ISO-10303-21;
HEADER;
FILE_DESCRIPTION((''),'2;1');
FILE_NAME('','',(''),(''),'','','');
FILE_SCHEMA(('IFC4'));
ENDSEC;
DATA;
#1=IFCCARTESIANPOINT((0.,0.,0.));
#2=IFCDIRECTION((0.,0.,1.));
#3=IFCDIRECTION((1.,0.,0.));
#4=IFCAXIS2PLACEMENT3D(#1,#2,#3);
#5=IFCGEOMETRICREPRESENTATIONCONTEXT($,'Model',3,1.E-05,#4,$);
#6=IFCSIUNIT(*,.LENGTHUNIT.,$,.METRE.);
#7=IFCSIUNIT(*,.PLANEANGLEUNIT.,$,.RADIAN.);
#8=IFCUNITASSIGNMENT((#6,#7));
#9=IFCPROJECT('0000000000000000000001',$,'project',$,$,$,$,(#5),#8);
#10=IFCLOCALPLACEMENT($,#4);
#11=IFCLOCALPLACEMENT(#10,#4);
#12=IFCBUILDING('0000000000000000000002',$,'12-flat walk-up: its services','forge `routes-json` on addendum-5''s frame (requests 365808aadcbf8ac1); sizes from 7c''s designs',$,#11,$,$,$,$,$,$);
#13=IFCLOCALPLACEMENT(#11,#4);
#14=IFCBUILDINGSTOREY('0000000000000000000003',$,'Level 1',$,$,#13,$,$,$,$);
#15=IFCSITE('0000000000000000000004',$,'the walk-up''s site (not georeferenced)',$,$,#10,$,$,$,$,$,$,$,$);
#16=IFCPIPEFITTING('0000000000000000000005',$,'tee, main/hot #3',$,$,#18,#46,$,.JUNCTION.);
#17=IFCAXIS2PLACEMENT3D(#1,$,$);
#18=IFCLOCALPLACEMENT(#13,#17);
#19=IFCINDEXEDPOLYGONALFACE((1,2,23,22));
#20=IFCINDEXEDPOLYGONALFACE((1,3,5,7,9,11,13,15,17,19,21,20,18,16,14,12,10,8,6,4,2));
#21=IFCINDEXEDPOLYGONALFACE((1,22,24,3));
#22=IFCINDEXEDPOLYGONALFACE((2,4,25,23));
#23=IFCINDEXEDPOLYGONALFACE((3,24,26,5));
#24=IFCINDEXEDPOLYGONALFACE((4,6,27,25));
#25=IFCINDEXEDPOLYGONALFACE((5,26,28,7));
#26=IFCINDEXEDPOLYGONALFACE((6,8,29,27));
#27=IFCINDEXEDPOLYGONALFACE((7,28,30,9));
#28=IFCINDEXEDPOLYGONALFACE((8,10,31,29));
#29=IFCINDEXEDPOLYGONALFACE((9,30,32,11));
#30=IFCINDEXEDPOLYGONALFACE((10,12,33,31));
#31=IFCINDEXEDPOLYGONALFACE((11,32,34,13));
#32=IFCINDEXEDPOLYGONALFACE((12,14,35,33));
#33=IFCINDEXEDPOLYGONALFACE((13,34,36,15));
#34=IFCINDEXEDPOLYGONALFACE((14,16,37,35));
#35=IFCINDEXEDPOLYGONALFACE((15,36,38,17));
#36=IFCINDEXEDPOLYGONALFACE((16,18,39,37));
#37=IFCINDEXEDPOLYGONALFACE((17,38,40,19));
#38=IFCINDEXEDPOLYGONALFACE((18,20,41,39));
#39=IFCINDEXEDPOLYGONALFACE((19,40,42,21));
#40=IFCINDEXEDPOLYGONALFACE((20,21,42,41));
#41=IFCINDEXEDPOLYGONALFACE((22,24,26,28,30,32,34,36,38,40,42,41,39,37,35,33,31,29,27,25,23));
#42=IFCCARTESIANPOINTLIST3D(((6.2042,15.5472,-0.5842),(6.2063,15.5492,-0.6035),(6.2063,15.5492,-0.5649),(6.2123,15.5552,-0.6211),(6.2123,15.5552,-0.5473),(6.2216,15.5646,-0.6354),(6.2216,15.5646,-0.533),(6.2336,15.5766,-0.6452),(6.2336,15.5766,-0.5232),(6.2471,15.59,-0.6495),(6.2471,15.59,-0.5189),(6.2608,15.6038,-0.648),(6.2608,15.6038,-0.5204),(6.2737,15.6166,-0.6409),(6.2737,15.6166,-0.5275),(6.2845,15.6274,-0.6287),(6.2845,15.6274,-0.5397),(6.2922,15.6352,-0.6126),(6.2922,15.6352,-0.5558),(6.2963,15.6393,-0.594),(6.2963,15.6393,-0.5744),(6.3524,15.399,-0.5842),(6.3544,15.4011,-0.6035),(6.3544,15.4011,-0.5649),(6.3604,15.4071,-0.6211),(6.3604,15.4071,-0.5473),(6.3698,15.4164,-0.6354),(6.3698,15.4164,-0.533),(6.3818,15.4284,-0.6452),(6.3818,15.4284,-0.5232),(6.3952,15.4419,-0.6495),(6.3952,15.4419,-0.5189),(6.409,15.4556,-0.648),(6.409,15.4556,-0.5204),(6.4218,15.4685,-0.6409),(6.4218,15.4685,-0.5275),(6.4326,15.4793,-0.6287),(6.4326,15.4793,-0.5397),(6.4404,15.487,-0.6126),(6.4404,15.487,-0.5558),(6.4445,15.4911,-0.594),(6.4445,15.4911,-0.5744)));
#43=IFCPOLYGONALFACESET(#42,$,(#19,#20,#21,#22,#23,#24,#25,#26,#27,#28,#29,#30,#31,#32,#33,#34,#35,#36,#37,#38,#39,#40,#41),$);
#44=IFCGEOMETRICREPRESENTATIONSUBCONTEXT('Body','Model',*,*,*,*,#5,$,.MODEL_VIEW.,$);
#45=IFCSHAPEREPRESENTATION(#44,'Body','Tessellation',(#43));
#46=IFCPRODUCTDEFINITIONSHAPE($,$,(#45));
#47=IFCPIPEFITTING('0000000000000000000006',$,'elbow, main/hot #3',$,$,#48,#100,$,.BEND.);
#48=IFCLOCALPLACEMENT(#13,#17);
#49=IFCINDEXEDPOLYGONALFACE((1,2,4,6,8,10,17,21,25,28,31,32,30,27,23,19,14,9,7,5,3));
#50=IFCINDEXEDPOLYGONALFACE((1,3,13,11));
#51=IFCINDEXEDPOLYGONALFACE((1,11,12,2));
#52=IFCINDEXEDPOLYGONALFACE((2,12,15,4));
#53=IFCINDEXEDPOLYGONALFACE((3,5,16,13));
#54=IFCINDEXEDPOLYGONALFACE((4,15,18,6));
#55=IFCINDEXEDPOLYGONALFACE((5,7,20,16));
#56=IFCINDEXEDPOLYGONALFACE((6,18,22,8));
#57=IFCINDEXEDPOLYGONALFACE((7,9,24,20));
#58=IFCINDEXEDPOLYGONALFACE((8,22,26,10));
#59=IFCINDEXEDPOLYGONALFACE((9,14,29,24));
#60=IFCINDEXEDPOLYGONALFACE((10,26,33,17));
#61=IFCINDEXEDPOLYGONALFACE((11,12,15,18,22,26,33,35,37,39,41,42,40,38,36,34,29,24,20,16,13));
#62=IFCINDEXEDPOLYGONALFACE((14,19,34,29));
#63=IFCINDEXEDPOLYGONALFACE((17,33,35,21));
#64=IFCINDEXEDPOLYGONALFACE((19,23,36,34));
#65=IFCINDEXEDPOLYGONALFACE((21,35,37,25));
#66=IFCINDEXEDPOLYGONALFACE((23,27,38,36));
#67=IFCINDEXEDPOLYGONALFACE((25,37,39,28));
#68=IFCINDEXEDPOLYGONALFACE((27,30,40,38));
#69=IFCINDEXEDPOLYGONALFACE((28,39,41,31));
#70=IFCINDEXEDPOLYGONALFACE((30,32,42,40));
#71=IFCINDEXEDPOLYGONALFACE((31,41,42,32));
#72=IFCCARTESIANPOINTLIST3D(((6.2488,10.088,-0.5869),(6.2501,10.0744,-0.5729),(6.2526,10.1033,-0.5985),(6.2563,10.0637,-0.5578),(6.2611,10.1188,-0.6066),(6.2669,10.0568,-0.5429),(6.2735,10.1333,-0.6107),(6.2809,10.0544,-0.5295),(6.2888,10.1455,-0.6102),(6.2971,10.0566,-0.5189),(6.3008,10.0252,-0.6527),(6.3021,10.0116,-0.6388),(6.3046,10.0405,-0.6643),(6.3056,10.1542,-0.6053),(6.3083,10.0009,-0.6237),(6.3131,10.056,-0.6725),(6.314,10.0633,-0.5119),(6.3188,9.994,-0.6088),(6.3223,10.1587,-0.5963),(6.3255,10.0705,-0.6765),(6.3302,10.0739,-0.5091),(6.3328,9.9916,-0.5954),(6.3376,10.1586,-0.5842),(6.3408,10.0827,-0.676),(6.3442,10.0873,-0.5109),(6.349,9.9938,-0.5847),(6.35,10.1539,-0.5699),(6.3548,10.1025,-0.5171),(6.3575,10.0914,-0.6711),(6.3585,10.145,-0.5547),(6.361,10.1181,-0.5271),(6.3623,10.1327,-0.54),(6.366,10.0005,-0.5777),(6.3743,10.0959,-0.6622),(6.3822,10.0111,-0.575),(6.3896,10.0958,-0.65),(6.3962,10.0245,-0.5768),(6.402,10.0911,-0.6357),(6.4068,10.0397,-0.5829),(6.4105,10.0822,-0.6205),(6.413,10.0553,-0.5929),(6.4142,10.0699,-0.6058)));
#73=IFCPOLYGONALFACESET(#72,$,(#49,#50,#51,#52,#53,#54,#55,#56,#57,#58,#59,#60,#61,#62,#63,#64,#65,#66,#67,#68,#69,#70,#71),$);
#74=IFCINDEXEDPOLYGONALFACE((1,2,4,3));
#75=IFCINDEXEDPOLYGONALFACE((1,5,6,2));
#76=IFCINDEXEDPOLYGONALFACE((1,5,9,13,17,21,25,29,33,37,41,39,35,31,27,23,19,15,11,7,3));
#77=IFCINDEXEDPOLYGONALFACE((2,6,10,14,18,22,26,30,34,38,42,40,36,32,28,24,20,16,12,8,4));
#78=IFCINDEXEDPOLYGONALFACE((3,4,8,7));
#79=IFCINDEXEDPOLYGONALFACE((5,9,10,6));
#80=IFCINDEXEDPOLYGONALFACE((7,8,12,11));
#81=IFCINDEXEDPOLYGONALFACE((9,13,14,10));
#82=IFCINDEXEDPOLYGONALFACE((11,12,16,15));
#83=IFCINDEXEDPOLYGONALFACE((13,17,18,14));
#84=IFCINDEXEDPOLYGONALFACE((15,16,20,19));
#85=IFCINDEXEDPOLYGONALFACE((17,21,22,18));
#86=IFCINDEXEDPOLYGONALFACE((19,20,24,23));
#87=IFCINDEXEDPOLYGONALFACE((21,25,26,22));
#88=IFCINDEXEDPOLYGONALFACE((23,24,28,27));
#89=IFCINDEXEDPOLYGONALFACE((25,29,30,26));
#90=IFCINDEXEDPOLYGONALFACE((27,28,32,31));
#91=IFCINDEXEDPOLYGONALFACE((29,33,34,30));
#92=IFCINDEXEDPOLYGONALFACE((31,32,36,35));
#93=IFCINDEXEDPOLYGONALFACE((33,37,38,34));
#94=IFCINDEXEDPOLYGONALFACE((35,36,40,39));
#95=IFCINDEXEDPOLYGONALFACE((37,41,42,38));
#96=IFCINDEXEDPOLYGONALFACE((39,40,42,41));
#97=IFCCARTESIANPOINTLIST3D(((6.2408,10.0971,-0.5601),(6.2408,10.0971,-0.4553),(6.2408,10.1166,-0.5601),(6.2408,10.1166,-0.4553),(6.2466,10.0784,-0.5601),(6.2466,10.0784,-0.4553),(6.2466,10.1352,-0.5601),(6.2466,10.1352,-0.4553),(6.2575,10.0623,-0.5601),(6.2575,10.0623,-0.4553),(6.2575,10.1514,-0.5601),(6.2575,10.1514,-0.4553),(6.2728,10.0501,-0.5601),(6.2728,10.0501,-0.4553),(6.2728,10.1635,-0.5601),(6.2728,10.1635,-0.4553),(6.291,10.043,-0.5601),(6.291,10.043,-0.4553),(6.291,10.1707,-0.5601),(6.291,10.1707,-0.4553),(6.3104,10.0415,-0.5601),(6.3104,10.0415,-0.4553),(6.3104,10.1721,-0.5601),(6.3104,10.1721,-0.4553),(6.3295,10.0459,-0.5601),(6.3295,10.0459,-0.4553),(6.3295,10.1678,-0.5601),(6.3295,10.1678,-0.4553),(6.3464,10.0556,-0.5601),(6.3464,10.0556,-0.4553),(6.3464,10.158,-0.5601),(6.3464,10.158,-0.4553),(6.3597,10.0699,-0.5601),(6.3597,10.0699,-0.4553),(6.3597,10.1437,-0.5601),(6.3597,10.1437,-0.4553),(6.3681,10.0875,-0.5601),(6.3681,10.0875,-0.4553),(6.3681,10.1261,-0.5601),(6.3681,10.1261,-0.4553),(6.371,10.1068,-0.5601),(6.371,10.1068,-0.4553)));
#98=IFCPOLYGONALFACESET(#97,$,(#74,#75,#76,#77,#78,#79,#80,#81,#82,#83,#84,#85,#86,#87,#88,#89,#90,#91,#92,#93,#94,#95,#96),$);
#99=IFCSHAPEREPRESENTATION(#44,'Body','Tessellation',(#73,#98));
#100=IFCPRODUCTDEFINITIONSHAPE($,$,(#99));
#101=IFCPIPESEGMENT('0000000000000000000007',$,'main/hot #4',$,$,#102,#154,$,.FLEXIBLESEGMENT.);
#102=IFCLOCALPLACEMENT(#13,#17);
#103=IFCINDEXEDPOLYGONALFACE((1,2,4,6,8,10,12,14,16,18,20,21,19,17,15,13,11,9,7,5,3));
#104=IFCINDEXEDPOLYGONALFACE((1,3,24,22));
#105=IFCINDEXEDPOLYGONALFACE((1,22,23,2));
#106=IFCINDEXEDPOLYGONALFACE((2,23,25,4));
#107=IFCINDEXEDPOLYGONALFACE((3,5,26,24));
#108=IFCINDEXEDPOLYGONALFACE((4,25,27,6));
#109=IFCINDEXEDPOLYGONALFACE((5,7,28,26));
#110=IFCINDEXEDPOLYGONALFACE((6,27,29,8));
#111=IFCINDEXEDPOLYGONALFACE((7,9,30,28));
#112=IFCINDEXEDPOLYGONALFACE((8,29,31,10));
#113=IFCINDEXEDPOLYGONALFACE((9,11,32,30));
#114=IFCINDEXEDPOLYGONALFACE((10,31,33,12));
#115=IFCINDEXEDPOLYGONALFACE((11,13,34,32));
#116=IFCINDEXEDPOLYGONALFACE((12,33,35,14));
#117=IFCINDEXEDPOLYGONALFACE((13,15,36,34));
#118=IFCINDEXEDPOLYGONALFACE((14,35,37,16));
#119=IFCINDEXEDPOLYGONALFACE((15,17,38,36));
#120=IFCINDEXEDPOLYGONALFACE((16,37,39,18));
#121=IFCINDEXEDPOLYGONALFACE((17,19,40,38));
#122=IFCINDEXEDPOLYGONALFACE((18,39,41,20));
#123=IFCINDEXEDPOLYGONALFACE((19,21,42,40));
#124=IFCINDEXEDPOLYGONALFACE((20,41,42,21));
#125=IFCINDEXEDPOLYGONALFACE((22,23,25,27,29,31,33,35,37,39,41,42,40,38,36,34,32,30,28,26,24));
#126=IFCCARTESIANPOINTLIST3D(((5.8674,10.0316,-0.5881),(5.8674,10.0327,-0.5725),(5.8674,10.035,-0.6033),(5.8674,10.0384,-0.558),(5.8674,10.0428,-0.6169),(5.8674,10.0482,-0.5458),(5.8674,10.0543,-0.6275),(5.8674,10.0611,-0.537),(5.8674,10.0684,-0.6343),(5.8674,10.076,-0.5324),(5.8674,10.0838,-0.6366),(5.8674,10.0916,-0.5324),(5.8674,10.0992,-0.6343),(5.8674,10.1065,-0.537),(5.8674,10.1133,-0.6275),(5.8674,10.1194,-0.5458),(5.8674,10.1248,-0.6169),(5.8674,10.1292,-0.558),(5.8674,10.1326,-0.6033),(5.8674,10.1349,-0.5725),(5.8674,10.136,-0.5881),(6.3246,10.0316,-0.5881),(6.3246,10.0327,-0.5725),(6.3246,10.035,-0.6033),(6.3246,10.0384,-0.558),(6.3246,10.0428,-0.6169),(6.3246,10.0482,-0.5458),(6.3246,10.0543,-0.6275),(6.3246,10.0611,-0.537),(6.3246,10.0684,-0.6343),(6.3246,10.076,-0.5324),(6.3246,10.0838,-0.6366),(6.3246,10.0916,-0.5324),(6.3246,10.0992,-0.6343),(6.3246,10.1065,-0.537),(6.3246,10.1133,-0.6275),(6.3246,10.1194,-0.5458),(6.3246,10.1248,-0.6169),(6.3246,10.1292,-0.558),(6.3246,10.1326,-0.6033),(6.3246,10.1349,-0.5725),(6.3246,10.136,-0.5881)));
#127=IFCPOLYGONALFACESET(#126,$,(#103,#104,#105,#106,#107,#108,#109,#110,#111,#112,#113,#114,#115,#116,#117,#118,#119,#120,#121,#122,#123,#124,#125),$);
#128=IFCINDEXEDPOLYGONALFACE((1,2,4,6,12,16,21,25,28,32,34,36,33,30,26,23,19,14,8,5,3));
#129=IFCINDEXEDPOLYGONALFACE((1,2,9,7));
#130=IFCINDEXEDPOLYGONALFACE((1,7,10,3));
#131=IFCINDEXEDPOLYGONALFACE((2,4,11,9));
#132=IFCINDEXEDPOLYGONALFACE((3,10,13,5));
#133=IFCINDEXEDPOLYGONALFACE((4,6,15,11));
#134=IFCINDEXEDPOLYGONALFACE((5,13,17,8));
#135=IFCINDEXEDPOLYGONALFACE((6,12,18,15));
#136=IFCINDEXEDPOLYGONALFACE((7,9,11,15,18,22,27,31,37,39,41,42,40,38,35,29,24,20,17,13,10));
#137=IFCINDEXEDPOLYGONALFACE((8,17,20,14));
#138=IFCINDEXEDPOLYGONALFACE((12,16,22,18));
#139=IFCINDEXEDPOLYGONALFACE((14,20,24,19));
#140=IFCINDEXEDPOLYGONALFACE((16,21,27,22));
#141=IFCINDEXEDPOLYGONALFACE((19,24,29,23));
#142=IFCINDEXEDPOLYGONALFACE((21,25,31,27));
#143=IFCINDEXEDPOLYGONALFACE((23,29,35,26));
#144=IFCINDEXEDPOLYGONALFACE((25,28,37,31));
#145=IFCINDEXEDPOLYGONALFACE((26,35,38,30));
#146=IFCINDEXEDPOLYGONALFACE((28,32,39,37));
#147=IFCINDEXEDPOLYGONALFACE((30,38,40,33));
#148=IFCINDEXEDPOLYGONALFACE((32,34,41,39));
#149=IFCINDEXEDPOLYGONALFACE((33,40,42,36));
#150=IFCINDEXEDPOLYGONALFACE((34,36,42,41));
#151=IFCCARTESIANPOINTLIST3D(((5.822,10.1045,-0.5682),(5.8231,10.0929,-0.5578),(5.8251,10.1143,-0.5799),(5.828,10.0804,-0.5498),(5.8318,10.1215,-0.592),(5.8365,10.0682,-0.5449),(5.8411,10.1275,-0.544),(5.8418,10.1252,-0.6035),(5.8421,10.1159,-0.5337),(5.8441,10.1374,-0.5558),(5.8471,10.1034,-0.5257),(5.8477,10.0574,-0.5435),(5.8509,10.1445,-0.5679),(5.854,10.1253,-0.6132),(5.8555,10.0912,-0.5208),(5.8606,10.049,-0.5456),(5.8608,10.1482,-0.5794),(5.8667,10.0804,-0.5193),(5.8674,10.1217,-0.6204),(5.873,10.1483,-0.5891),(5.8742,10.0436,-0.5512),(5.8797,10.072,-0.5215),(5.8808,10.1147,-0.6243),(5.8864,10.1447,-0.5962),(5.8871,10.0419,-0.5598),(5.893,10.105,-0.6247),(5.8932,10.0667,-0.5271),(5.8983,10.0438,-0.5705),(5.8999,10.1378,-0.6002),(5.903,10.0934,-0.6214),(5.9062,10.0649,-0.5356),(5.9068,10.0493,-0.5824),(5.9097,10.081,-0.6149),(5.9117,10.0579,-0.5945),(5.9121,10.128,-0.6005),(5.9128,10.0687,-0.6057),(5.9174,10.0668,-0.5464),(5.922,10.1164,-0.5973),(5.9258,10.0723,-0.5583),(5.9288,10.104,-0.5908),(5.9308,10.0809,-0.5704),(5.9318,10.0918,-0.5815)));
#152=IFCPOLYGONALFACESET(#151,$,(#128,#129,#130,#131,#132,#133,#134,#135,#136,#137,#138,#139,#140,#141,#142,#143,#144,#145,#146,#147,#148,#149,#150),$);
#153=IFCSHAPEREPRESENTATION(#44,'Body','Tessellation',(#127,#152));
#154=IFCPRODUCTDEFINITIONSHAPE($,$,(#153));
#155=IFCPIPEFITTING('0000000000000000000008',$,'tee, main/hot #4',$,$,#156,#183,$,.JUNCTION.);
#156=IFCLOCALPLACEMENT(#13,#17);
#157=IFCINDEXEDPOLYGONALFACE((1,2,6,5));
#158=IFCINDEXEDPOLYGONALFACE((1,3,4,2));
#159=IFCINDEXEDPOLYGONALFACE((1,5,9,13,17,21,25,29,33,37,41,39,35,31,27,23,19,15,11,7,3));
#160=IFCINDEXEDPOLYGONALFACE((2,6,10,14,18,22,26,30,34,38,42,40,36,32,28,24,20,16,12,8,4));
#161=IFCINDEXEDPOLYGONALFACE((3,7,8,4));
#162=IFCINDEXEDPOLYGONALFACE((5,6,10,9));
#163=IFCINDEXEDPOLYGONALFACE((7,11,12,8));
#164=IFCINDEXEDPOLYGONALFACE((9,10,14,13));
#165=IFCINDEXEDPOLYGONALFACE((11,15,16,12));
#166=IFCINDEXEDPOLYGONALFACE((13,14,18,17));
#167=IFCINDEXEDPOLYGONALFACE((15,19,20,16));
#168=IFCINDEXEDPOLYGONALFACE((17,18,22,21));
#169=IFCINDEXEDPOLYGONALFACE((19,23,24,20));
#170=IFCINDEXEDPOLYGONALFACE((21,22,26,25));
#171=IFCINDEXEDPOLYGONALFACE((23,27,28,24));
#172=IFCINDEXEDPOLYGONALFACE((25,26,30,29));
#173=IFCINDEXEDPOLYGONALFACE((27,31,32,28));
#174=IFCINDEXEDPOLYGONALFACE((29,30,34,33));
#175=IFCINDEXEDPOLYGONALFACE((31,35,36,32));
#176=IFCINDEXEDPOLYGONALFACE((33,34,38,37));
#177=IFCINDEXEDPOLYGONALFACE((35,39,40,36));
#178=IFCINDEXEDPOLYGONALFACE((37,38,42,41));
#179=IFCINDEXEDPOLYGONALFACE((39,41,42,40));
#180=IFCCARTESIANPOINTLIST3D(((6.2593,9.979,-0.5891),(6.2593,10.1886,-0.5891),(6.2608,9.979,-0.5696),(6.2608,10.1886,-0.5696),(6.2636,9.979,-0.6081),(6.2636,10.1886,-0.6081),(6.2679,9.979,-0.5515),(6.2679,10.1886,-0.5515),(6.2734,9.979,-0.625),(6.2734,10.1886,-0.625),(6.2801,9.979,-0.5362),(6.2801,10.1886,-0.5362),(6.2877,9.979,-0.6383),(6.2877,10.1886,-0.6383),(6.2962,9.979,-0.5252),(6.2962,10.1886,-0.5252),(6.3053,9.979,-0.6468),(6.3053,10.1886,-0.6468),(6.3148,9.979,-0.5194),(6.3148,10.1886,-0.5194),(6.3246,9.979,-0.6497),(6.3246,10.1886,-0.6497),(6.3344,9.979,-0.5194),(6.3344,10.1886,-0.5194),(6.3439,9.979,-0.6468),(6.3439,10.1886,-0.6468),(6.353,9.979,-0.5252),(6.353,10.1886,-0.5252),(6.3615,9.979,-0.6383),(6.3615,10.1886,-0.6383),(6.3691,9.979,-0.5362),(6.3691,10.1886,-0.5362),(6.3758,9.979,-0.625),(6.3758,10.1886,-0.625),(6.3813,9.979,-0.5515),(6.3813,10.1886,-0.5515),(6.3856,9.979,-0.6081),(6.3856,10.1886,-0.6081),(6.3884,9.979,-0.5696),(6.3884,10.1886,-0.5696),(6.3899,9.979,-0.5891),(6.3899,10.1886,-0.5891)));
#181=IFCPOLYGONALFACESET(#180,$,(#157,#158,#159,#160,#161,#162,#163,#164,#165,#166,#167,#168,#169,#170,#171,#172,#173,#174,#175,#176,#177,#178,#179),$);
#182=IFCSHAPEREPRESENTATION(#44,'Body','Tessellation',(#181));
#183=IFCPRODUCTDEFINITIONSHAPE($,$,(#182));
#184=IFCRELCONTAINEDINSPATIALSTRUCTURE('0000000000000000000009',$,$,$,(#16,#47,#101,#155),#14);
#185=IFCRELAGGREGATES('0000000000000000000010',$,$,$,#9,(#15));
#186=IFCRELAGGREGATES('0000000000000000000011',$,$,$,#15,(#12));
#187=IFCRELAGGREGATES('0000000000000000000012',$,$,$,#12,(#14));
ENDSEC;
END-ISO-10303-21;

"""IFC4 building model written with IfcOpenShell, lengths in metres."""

from ifc_helpers import new_model, entity, si_unit, frame, origin_with_axes, place, context, subcontext, project, spatial, element, save


model = new_model("IFC4")

# Units and contexts
model_context = context("Model", 3, precision=1e-05, world=origin_with_axes())
body_context = subcontext(model_context, "Body", "Model", "MODEL_VIEW")
ifc_project = project(units=[si_unit("LENGTHUNIT", "METRE"), si_unit("PLANEANGLEUNIT", "RADIAN")], contexts=[model_context])

# Site, building, storey
site_placement = place(None, origin_with_axes())
site = spatial("IfcSite", under=ifc_project, at=site_placement, Name="the walk-up's site (not georeferenced)")
building_placement = place(site_placement, origin_with_axes())
building = spatial("IfcBuilding", under=site, at=building_placement, Name="12-flat walk-up: its services", Description="forge `routes-json` on addendum-5's frame (requests 365808aadcbf8ac1); sizes from 7c's designs")
storey_placement = place(building_placement, origin_with_axes())
storey = spatial("IfcBuildingStorey", under=building, at=storey_placement, Name="Level 1")

# Pipe fittings
pipe_fitting_1_placement = place(storey_placement, frame((6.3987, 15.4453, -0.5842), z_axis=(0.0, 0.0, 1.0), x_axis=(1.0, 0.0, 0.0)))
element("IfcPipeFitting", 1, at=pipe_fitting_1_placement, inside=storey, Name="tee, main/hot #3", PredefinedType="JUNCTION", context=body_context, shape_type="AdvancedSweptSolid", body=[
    entity("IfcSweptDiskSolid", entity("IfcPolyline", [entity("IfcCartesianPoint", [0.0, 0.0, 0.0]), entity("IfcCartesianPoint", [-0.1482, 0.1482, 0.0])]), 0.0655),
])
pipe_fitting_2_placement = place(storey_placement, frame((6.3575, 10.044, -0.6259), z_axis=(0.0, 0.0, 1.0), x_axis=(1.0, 0.0, 0.0)))
element("IfcPipeFitting", 2, at=pipe_fitting_2_placement, inside=storey, Name="elbow, main/hot #3", PredefinedType="BEND", context=body_context, shape_type="AdvancedSweptSolid", body=[
    entity("IfcSweptDiskSolid", entity("IfcPolyline", [entity("IfcCartesianPoint", [0.0, 0.0, 0.0]), entity("IfcCartesianPoint", [-0.052, 0.0628, 0.0658])]), 0.0655),
    entity("IfcSweptDiskSolid", entity("IfcPolyline", [entity("IfcCartesianPoint", [-0.052, 0.0628, 0.0658]), entity("IfcCartesianPoint", [-0.052, 0.0628, 0.1706])]), 0.0655),
])

# Pipe segment
pipe_segment_1_placement = place(storey_placement, frame((6.3246, 10.0838, -0.5842), z_axis=(0.0, 0.0, 1.0), x_axis=(1.0, 0.0, 0.0)))
element("IfcPipeSegment", 3, at=pipe_segment_1_placement, inside=storey, Name="main/hot #4", PredefinedType="FLEXIBLESEGMENT", context=body_context, shape_type="AdvancedSweptSolid", body=[
    entity("IfcSweptDiskSolid", entity("IfcPolyline", [entity("IfcCartesianPoint", [0.0, 0.0, 0.0]), entity("IfcCartesianPoint", [-0.4572, 0.0, 0.0])]), 0.0524),
    entity("IfcSweptDiskSolid", entity("IfcPolyline", [entity("IfcCartesianPoint", [-0.4572, 0.0, 0.0]), entity("IfcCartesianPoint", [-0.4381, 0.023, 0.0241])]), 0.0524),
])

# Pipe fitting
pipe_fitting_3_placement = place(storey_placement, frame((6.3246, 10.1886, -0.5842), z_axis=(0.0, 0.0, 1.0), x_axis=(1.0, 0.0, 0.0)))
element("IfcPipeFitting", 4, at=pipe_fitting_3_placement, inside=storey, Name="tee, main/hot #4", PredefinedType="JUNCTION", context=body_context, shape_type="AdvancedSweptSolid", body=[
    entity("IfcSweptDiskSolid", entity("IfcPolyline", [entity("IfcCartesianPoint", [0.0, 0.0, 0.0]), entity("IfcCartesianPoint", [0.0, -0.2096, 0.0])]), 0.0655),
])

save(model, "model.ifc")
